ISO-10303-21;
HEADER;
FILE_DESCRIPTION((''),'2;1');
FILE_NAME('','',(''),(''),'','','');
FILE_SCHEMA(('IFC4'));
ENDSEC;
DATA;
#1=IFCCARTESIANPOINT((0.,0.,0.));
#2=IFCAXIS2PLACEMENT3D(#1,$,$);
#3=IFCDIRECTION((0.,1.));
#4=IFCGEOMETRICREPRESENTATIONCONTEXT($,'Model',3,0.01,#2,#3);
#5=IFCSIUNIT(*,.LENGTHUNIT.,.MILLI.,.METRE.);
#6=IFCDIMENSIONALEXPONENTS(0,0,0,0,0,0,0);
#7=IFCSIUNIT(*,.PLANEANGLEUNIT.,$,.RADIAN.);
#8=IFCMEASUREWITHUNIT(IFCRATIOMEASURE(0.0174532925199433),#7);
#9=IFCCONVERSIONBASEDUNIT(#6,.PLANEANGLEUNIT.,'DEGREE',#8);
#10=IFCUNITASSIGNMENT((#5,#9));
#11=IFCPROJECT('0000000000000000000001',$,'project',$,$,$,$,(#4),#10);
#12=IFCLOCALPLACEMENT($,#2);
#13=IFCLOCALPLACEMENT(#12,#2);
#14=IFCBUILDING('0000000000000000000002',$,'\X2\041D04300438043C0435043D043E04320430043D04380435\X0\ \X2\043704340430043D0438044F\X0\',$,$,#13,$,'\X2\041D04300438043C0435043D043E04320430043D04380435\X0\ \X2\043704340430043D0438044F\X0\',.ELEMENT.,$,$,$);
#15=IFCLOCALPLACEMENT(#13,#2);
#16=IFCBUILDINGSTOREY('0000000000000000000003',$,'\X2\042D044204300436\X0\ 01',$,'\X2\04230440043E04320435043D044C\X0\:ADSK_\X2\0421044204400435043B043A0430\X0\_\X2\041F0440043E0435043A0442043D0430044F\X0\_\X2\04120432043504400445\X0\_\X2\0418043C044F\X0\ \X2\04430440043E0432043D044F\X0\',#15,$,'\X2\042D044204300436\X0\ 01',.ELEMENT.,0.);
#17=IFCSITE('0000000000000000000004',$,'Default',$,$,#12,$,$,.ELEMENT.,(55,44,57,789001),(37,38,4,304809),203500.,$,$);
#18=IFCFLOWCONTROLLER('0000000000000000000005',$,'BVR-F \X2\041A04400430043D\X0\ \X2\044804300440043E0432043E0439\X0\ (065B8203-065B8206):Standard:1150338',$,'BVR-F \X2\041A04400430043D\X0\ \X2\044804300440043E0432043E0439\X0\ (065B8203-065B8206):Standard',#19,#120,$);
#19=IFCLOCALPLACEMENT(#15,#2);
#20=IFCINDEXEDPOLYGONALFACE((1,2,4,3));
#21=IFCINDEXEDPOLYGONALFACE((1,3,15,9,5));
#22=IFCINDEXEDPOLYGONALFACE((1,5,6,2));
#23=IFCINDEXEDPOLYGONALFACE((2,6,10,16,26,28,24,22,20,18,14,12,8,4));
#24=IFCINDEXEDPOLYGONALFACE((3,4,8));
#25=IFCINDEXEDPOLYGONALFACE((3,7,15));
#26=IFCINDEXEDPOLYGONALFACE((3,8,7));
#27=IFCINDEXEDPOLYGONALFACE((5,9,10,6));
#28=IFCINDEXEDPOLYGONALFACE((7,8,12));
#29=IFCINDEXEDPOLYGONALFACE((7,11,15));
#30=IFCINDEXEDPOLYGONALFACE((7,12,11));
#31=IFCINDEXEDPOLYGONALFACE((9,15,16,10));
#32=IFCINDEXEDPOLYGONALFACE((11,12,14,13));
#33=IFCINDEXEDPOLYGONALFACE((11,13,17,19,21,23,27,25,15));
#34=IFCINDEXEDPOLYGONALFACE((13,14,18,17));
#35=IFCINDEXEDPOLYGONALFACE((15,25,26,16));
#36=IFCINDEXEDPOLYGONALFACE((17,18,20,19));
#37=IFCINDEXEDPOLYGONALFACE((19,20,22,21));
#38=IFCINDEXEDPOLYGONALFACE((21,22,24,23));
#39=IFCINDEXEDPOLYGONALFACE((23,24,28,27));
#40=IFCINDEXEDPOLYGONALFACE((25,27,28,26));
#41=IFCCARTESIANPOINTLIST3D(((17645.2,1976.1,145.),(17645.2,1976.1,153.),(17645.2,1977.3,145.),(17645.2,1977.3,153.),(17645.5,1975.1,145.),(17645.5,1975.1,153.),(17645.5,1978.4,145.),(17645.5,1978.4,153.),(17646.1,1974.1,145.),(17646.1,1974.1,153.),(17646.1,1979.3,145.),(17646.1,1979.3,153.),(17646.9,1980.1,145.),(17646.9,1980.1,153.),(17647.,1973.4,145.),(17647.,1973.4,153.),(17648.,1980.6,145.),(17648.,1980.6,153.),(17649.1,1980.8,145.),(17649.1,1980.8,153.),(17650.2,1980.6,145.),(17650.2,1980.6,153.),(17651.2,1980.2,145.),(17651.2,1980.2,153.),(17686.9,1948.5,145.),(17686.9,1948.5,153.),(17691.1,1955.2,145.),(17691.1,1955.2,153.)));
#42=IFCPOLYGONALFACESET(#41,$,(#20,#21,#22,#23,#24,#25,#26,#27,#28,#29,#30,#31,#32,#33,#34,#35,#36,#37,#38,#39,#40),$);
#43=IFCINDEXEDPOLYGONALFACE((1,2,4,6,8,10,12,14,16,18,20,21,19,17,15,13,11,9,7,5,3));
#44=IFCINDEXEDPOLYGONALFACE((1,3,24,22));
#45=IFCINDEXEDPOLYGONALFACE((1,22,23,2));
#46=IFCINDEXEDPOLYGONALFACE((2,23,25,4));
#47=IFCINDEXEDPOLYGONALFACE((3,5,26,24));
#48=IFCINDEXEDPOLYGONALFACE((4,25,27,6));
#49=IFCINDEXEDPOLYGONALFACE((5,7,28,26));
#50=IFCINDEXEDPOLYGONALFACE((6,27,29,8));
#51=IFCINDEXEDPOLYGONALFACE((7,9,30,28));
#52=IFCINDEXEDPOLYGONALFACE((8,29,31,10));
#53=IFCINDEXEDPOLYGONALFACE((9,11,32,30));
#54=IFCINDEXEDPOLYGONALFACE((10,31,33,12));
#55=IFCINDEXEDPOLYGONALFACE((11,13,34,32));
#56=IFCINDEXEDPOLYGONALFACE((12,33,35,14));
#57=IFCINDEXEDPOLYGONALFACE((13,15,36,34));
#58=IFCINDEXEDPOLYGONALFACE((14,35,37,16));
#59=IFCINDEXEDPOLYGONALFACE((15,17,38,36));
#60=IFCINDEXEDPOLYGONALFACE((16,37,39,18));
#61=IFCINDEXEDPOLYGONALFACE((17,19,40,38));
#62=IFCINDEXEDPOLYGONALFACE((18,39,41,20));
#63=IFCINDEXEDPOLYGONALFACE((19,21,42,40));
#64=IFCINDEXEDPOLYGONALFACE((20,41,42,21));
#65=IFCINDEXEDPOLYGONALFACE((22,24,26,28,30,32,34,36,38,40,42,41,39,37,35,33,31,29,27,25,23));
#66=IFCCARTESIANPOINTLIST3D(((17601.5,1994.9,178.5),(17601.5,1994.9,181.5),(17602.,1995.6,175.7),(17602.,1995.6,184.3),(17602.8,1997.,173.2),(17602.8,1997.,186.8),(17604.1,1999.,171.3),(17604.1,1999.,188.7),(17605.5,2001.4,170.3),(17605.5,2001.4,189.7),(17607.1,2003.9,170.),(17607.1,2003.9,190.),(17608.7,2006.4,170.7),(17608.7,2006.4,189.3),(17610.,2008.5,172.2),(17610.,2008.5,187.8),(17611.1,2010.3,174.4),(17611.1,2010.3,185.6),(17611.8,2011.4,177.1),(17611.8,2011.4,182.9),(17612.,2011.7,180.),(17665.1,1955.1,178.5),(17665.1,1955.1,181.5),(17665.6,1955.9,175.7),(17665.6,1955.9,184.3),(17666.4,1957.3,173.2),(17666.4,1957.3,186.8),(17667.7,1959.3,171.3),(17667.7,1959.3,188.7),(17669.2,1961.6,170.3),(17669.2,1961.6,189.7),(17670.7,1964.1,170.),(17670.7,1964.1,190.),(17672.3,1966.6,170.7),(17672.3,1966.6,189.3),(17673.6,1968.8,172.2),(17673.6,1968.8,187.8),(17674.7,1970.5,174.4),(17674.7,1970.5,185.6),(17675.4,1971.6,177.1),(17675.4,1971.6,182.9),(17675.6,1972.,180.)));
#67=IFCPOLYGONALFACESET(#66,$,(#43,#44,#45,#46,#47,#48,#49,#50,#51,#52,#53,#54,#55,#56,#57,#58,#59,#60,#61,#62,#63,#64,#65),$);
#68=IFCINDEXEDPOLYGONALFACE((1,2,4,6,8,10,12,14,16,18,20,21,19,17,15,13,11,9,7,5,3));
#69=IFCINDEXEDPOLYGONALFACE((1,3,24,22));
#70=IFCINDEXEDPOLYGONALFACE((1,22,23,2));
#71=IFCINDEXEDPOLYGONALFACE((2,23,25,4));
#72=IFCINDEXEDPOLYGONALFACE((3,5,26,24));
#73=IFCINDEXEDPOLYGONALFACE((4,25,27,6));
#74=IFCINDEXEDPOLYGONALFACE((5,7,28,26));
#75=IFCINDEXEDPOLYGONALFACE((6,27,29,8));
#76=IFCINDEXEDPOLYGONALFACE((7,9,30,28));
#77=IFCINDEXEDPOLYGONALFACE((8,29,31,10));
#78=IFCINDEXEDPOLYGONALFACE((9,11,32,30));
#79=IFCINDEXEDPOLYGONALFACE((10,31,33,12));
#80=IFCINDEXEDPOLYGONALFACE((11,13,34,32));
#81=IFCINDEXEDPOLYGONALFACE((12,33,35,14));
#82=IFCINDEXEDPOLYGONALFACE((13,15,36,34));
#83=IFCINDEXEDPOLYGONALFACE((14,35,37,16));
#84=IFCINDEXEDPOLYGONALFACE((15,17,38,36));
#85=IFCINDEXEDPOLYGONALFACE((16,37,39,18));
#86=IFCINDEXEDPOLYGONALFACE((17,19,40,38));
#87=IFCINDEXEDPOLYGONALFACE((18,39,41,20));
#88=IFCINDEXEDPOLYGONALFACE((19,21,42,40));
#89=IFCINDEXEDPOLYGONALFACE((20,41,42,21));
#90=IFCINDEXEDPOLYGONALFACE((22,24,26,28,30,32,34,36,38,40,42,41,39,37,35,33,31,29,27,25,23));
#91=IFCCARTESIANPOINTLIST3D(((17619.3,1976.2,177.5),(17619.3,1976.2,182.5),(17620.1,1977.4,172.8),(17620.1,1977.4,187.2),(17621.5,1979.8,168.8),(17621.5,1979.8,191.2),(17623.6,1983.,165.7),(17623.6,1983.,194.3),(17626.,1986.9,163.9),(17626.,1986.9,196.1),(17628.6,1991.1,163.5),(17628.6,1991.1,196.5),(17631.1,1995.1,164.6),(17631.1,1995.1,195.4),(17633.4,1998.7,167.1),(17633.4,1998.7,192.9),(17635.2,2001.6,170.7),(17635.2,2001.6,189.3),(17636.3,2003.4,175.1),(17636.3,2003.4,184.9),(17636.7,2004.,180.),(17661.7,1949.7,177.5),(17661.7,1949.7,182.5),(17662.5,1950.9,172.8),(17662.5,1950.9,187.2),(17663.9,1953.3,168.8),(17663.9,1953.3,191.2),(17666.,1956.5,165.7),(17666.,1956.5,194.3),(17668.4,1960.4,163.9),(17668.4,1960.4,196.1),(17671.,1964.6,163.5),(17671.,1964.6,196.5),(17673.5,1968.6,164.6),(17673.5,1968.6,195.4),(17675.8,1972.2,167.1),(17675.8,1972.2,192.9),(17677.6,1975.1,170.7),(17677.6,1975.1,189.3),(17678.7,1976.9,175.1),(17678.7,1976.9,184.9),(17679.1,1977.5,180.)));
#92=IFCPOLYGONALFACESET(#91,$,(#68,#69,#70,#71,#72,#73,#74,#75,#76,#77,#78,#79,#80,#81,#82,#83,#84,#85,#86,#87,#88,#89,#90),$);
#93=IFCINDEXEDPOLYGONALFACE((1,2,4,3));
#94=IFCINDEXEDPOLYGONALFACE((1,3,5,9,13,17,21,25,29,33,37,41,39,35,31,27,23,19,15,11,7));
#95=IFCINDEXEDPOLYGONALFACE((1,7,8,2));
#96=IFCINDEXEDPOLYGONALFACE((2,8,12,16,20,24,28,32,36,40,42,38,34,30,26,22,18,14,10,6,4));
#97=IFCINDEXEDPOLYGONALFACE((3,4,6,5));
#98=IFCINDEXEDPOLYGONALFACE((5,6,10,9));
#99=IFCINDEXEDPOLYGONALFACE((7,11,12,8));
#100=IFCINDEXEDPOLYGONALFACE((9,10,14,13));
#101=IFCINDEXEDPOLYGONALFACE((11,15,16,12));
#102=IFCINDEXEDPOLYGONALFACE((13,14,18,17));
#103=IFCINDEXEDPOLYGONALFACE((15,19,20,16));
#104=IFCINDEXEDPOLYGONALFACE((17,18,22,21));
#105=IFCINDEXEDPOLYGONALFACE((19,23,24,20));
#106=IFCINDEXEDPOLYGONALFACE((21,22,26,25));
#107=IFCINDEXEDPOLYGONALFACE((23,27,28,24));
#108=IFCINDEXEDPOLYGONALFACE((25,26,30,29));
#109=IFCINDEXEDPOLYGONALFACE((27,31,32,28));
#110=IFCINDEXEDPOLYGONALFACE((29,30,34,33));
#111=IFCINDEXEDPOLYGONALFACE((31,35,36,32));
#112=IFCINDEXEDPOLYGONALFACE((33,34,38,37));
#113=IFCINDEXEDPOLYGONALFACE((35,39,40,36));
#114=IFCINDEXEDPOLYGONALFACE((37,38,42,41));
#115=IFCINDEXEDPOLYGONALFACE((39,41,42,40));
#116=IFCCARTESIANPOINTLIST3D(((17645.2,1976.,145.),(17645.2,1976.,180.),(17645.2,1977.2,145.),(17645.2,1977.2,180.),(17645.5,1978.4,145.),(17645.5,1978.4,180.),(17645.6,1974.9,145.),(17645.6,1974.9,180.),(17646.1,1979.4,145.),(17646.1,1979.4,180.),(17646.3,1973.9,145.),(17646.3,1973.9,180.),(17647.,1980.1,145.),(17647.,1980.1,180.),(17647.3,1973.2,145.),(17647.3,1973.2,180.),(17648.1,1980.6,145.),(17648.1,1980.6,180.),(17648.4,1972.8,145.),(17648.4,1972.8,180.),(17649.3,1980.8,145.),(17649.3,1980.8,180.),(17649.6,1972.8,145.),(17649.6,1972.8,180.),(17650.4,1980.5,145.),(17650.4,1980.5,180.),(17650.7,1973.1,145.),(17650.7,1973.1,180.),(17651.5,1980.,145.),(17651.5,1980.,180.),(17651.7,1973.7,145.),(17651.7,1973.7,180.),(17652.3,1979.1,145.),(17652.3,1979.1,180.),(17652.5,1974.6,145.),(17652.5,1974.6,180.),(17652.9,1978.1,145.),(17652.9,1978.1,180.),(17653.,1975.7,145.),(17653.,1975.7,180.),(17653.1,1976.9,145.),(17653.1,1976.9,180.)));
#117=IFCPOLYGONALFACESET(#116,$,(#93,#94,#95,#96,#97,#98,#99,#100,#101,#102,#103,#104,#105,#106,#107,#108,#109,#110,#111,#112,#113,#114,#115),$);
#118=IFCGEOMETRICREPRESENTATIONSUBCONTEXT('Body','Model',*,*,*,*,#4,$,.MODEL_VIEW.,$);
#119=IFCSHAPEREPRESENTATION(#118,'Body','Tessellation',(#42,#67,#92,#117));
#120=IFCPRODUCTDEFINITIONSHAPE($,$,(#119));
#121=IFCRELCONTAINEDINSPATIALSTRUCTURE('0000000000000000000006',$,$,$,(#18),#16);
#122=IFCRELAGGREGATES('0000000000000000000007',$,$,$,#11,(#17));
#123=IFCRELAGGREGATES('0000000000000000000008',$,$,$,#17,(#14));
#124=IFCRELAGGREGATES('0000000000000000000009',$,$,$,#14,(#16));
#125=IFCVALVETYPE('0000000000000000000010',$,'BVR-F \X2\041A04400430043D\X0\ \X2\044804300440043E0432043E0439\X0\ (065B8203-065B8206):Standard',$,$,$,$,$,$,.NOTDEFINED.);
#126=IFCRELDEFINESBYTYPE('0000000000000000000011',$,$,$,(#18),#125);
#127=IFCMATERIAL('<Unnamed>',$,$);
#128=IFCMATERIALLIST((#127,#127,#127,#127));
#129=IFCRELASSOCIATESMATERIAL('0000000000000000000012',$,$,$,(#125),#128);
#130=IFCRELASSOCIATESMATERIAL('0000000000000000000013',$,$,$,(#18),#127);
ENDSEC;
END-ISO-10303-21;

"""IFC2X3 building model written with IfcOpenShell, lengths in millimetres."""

from ifc_helpers import new_model, entity, si_unit, converted_unit, direction, frame, frame_2d, origin, origin_2d_with_axis, place, context, subcontext, project, spatial, polyline, circle_curve, parameter, trimmed, segment, composite_curve, circle, outline, extrude, source, transform, mapped, material, material_list, type_object, type_shapes, element, save


model = new_model("IFC2X3")

# Units and contexts
model_context = context("Model", 3, precision=0.01, world=origin(), true_north=direction((0.0, 1.0)))
body_context = subcontext(model_context, "Body", "Model", "MODEL_VIEW")
ifc_project = project(units=[si_unit("LENGTHUNIT", "METRE", prefix="MILLI"), converted_unit("PLANEANGLEUNIT", "DEGREE", entity("IfcRatioMeasure", 0.0174532925199433), si_unit("PLANEANGLEUNIT", "RADIAN"), dimensions=[0, 0, 0, 0, 0, 0, 0])], contexts=[model_context])

# Site, building, storey
site_placement = place(None, origin())
site = spatial("IfcSite", under=ifc_project, at=site_placement, Name="Default", CompositionType="ELEMENT", RefLatitude=(55, 44, 57, 789001), RefLongitude=(37, 38, 4, 304809), RefElevation=203500.0)
building_placement = place(site_placement, origin())
building = spatial("IfcBuilding", under=site, at=building_placement, Name="Наименование здания", LongName="Наименование здания", CompositionType="ELEMENT")
storey_placement = place(building_placement, origin())
storey = spatial("IfcBuildingStorey", under=building, at=storey_placement, Name="Этаж 01", ObjectType="Уровень:ADSK_Стрелка_Проектная_Вверх_Имя уровня", LongName="Этаж 01", CompositionType="ELEMENT", Elevation=0.0)

# Flow controller
ifc_material = material(Name="<Unnamed>")
ifc_material_list = material_list([ifc_material, ifc_material, ifc_material, ifc_material])
valve_type_1 = type_object("IfcValveType", Name="BVR-F Кран шаровой (065B8203-065B8206):Standard", PredefinedType="NOTDEFINED", material=ifc_material_list)
shared_shape_1 = source(origin(), body_context, "Body", "SweptSolid", [
    extrude(outline(composite_curve([segment(trimmed(circle_curve(frame_2d((-23.5, 0.0), x_axis=(1.0, 0.0)), 4.0), [parameter(90.0)], [parameter(270.0)], True, "PARAMETER"), True, "CONTINUOUS"), segment(polyline([(-23.5, -4.0), (23.5, -4.0)]), True, "CONTINUOUS"), segment(polyline([(23.5, -4.0), (23.5, 4.0)]), True, "CONTINUOUS"), segment(polyline([(23.5, 4.0), (-23.5, 4.0)]), True, "CONTINUOUS")], self_intersect=False)), frame((23.5, 0.0, 26.9)), (0.0, 0.0, 1.0), 8.0),
    extrude(circle(Radius=10.0, at=origin_2d_with_axis()), frame((-50.0, 0.0, 0.0), z_axis=(1.0, 0.0, 0.0), x_axis=(0.0, -1.0, 0.0)), (0.0, 0.0, 1.0), 75.0),
    extrude(circle(Radius=16.5, at=origin_2d_with_axis()), frame((-25.0, 0.0, 0.0), z_axis=(1.0, 0.0, 0.0), x_axis=(0.0, -1.0, 0.0)), (0.0, 0.0, 1.0), 50.0),
    extrude(circle(Radius=4.0, at=origin_2d_with_axis()), origin(), (0.0, 0.0, 1.0), 35.0),
])
type_shapes(valve_type_1, [shared_shape_1])
flow_controller_1_placement = place(storey_placement, frame((17649.1, 1976.8, 180.0), z_axis=(0.0, 0.0, -1.0), x_axis=(0.848048, -0.529919, 0.0)))
element("IfcFlowController", 1, at=flow_controller_1_placement, inside=storey, type_object=valve_type_1, material=ifc_material, Name="BVR-F Кран шаровой (065B8203-065B8206):Standard:1150338", ObjectType="BVR-F Кран шаровой (065B8203-065B8206):Standard", context=body_context, shape_type="MappedRepresentation", body=[
    mapped(shared_shape_1, transform((0.0, 0.0, 0.0), scale=1.0)),
])

save(model, "model.ifc")
